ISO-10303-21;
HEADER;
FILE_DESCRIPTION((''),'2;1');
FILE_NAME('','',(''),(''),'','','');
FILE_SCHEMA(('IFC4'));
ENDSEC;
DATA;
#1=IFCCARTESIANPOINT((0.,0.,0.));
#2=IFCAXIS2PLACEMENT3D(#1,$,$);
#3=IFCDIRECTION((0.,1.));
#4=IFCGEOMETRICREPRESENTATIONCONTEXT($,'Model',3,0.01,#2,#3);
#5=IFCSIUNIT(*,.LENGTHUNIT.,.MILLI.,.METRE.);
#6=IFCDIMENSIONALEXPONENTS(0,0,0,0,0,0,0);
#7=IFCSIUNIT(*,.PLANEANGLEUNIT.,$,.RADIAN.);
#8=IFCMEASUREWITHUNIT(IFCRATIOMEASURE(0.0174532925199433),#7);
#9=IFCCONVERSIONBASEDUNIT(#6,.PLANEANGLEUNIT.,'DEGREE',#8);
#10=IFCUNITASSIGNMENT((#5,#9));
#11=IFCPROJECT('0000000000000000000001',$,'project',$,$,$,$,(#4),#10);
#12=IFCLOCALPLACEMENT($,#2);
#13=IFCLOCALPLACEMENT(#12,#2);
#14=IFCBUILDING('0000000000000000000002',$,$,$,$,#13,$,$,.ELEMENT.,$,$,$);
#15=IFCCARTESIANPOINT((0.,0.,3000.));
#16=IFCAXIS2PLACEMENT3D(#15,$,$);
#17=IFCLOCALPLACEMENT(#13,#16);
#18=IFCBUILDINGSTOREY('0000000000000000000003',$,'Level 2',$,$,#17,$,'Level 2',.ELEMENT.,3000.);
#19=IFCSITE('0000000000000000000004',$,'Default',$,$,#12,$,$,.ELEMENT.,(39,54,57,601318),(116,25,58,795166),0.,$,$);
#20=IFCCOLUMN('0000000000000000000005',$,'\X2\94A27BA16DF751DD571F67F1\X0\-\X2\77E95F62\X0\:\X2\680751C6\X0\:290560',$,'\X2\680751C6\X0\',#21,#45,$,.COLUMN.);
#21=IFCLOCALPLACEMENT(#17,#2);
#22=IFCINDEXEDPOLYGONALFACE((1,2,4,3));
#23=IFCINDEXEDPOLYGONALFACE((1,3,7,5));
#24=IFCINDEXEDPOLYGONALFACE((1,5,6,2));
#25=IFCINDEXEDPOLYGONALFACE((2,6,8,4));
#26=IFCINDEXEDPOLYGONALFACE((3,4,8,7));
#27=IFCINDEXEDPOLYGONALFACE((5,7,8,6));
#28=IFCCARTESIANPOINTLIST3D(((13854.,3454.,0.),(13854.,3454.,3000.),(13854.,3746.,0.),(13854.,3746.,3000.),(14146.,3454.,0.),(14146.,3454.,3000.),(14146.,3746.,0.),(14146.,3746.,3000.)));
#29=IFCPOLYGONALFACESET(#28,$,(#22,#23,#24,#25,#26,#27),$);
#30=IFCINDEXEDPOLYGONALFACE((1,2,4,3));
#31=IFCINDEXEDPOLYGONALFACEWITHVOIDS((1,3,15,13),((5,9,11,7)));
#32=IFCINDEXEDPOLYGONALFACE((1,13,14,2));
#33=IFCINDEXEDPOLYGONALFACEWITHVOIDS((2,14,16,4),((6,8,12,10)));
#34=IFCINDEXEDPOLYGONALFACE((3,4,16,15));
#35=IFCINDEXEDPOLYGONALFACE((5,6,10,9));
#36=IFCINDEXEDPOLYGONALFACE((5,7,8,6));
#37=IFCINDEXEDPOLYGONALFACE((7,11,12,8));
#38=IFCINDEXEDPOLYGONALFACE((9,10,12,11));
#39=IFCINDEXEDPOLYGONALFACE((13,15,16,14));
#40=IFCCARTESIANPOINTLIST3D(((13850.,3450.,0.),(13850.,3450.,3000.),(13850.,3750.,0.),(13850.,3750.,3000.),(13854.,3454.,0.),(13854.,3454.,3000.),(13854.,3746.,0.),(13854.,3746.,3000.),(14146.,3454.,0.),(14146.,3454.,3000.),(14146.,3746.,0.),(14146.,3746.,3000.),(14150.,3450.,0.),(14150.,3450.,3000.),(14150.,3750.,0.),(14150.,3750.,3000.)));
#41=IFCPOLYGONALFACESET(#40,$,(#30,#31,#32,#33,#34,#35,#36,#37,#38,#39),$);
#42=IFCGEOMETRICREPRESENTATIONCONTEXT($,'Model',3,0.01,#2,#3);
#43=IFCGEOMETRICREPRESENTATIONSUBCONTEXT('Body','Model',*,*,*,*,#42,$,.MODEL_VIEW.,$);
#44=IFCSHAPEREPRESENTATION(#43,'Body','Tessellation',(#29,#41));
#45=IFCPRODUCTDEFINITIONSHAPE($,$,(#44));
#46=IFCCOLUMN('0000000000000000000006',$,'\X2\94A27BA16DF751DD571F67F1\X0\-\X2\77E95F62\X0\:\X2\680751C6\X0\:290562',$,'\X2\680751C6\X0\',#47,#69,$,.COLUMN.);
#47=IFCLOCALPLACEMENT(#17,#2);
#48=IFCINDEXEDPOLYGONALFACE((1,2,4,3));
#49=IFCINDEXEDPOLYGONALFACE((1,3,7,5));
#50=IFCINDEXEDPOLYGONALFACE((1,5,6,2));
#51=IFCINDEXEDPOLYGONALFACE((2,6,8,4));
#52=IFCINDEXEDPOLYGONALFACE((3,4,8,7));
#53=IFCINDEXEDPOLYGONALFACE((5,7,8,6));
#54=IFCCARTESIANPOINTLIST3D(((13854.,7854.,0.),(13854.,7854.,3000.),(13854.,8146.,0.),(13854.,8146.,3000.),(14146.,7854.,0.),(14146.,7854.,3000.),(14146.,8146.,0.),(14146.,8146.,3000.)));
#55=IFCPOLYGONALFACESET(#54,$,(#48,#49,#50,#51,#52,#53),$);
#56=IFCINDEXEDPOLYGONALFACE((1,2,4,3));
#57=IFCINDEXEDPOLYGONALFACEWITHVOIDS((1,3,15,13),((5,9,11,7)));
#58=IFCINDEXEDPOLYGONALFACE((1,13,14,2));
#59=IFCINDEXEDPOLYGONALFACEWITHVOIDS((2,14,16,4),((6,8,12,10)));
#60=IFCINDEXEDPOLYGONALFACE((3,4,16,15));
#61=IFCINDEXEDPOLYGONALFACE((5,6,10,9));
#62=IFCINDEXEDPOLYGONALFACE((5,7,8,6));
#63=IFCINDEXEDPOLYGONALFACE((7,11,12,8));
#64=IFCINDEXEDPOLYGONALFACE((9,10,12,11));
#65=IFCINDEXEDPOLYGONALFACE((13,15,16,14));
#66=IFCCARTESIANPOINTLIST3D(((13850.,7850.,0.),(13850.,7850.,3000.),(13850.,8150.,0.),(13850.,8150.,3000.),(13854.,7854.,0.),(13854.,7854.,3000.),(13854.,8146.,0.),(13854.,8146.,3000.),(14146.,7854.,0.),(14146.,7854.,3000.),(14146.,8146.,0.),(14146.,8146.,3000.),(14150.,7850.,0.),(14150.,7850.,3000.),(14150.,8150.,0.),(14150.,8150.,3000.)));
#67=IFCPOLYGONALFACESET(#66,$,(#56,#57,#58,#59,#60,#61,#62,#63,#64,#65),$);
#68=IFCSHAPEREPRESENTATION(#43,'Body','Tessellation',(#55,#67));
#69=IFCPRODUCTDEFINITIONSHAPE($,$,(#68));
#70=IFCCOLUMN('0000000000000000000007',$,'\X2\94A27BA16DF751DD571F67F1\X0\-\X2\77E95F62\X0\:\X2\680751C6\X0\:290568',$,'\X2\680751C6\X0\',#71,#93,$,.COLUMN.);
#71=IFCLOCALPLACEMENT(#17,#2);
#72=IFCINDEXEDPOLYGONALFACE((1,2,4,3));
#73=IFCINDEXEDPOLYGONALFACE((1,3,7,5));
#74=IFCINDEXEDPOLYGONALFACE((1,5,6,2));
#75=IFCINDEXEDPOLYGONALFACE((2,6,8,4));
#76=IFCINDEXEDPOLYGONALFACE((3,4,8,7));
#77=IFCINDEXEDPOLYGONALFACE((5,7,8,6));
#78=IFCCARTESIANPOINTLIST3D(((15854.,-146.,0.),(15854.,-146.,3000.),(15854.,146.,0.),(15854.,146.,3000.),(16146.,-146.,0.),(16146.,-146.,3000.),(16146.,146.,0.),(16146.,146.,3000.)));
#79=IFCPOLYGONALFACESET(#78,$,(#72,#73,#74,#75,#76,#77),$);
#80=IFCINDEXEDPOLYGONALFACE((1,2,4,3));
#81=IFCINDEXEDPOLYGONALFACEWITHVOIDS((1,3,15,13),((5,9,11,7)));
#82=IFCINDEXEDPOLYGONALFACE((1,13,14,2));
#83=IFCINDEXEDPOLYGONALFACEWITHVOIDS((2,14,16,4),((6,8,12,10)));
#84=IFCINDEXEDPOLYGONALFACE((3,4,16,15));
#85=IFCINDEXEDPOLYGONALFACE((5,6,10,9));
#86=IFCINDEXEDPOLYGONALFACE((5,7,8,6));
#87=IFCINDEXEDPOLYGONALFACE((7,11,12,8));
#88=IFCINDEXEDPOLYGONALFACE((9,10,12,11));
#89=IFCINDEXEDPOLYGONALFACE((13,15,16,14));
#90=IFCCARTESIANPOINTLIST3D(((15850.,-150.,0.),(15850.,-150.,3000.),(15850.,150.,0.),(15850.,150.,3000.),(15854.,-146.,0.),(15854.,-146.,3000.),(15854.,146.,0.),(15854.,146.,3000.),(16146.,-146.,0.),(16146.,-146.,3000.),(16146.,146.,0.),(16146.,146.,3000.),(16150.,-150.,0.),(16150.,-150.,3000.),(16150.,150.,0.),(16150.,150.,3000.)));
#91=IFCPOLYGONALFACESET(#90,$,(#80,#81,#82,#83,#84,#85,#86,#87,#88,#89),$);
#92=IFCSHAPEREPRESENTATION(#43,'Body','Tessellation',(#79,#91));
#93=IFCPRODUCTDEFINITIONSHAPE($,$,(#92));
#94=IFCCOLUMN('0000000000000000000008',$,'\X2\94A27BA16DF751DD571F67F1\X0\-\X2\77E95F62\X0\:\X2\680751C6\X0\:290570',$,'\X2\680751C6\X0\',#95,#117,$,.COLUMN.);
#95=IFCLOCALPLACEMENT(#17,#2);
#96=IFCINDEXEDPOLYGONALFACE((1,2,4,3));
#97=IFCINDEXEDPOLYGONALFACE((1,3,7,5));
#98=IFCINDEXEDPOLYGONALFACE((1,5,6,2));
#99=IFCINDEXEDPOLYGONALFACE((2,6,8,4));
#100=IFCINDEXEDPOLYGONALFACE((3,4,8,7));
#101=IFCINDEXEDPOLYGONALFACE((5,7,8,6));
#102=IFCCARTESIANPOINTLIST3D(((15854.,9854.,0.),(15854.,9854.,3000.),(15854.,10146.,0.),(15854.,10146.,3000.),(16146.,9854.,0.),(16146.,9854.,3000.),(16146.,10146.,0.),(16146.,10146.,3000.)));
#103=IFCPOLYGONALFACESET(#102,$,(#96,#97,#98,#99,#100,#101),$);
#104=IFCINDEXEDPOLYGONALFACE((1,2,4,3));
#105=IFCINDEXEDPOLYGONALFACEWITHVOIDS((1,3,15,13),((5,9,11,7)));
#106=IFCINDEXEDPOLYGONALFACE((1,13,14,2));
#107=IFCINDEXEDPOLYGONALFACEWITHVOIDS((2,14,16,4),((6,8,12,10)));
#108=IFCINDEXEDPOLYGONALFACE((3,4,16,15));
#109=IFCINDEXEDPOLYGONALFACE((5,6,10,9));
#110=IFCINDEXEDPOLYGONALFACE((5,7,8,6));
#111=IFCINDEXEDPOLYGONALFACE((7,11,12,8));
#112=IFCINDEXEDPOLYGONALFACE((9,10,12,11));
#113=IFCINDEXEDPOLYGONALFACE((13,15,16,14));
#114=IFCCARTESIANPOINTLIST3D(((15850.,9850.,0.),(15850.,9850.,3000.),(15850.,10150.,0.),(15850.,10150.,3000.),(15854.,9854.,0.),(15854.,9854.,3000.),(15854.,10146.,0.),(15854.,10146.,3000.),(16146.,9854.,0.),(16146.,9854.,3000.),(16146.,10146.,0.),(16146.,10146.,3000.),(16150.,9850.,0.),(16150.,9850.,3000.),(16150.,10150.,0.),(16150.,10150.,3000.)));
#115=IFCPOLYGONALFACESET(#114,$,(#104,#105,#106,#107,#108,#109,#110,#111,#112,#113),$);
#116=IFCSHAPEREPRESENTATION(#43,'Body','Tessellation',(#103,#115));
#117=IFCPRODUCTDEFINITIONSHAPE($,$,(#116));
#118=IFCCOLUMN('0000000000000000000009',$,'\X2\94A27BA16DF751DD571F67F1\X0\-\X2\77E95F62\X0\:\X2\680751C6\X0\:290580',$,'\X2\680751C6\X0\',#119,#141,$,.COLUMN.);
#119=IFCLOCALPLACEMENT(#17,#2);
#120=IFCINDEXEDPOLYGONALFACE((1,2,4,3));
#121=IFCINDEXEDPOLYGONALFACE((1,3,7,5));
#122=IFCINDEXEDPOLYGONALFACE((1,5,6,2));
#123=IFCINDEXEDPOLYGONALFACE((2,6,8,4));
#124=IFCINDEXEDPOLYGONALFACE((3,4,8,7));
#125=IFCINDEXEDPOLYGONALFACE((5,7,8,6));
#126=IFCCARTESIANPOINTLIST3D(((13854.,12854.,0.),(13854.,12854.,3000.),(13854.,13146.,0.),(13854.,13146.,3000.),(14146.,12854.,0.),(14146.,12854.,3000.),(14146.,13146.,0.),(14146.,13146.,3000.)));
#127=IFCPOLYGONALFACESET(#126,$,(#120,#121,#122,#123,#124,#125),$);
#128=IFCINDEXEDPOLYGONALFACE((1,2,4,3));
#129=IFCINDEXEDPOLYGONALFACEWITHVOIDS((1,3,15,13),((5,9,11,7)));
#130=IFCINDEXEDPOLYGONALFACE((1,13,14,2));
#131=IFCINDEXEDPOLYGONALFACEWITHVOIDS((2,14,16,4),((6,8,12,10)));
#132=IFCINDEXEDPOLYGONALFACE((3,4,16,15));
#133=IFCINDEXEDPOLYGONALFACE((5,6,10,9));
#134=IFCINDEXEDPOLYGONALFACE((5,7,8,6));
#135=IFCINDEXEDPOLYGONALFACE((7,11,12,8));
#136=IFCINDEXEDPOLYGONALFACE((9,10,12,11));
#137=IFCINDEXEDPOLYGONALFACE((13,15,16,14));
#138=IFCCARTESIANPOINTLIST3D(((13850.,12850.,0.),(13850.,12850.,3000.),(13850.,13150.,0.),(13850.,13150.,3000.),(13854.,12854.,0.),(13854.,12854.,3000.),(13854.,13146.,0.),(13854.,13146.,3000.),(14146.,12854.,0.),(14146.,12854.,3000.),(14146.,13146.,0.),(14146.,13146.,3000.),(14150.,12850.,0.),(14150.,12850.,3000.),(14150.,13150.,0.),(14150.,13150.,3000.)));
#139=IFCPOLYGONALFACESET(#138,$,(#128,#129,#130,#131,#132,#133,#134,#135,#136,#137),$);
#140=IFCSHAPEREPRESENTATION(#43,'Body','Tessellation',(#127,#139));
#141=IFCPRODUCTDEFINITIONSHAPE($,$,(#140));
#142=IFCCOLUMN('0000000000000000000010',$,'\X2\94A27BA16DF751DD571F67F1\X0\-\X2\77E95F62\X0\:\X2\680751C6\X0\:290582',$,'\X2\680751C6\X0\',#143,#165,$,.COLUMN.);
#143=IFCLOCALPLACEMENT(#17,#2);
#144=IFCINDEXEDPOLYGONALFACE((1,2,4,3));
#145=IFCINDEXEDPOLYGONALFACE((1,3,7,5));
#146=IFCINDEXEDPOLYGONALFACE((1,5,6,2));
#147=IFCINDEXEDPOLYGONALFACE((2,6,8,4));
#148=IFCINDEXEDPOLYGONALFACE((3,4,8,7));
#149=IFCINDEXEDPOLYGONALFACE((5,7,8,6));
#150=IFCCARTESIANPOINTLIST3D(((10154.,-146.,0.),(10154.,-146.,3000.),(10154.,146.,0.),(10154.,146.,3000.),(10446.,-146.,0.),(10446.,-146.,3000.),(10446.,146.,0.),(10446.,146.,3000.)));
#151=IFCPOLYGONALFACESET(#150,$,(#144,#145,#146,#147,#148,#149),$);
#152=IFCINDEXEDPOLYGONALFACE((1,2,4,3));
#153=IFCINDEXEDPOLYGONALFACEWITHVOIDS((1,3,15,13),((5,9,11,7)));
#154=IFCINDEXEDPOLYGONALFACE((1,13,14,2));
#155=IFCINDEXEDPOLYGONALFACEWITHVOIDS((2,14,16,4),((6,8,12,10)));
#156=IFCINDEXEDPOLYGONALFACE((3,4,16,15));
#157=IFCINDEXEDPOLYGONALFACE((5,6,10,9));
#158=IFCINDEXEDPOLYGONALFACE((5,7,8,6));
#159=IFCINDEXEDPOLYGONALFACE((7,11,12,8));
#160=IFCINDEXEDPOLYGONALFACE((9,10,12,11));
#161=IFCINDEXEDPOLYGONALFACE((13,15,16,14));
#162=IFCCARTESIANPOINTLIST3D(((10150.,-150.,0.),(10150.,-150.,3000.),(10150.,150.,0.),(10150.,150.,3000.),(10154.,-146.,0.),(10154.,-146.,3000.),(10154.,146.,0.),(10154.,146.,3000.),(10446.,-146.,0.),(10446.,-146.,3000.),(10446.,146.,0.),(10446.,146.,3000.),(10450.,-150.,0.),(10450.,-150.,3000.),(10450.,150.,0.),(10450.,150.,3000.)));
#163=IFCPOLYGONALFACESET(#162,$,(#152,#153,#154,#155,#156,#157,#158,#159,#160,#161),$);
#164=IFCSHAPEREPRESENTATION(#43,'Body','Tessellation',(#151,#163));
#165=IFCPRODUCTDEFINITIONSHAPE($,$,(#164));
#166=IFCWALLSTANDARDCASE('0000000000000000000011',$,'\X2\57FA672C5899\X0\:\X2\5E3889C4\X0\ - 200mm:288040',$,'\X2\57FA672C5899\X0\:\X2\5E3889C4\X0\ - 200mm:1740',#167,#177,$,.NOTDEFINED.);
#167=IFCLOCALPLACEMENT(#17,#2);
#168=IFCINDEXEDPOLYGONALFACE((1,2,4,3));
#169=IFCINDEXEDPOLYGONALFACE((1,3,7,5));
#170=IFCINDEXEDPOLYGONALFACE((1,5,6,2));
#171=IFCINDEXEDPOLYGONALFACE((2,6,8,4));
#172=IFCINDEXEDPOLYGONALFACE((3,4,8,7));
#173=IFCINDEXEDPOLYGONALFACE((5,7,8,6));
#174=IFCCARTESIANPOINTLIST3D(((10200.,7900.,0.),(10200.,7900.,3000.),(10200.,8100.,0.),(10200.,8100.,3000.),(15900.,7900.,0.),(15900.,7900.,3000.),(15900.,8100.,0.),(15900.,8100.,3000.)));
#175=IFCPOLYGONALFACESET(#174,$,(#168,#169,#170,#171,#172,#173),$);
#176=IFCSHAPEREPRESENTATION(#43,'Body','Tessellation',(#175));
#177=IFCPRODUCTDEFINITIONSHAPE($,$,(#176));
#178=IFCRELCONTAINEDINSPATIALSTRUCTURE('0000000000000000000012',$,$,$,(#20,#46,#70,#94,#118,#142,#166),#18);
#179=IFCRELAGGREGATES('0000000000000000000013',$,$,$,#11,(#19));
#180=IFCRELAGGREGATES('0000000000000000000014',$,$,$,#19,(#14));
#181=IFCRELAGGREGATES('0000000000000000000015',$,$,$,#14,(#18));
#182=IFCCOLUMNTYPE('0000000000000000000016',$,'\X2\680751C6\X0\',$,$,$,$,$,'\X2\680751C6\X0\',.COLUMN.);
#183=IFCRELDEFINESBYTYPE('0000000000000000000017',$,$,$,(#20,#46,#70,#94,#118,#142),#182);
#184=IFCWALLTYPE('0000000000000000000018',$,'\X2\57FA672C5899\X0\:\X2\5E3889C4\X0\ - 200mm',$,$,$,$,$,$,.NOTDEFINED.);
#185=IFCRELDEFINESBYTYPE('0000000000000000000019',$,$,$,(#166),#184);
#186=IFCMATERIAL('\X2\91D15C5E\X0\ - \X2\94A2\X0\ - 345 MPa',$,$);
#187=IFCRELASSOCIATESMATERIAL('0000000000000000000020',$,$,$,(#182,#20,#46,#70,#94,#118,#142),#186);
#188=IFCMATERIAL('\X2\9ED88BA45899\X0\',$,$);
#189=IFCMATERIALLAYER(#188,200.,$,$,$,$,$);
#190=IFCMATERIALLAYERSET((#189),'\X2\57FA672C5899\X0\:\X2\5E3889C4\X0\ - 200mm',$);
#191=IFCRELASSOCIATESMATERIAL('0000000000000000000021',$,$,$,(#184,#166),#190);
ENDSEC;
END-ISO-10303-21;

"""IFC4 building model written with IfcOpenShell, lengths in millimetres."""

from ifc_helpers import new_model, entity, si_unit, converted_unit, direction, frame, frame_2d, origin, origin_2d_with_axis, place, context, subcontext, project, spatial, polyline, rectangle, outline, extrude, source, transform, mapped, material, layer, layer_set, layer_usage, type_object, type_shapes, element, save


model = new_model("IFC4")

# Units and contexts
model_context_1 = context("Model", 3, precision=0.01, world=origin(), true_north=direction((0.0, 1.0)))
model_context_2 = context("Model", 3, precision=0.01, world=origin(), true_north=direction((0.0, 1.0)))
body_context = subcontext(model_context_2, "Body", "Model", "MODEL_VIEW")
ifc_project = project(units=[si_unit("LENGTHUNIT", "METRE", prefix="MILLI"), converted_unit("PLANEANGLEUNIT", "DEGREE", entity("IfcRatioMeasure", 0.0174532925199433), si_unit("PLANEANGLEUNIT", "RADIAN"), dimensions=[0, 0, 0, 0, 0, 0, 0])], contexts=[model_context_1])

# Site, building, storey
site_placement = place(None, origin())
site = spatial("IfcSite", under=ifc_project, at=site_placement, Name="Default", CompositionType="ELEMENT", RefLatitude=(39, 54, 57, 601318), RefLongitude=(116, 25, 58, 795166), RefElevation=0.0)
building_placement = place(site_placement, origin())
building = spatial("IfcBuilding", under=site, at=building_placement, CompositionType="ELEMENT")
storey_placement = place(building_placement, frame((0.0, 0.0, 3000.0)))
storey = spatial("IfcBuildingStorey", under=building, at=storey_placement, Name="Level 2", LongName="Level 2", CompositionType="ELEMENT", Elevation=3000.0)

# Columns
ifc_material_1 = material(Name="金属 - 钢 - 345 MPa")
column_type = type_object("IfcColumnType", Name="标准", ElementType="标准", PredefinedType="COLUMN", material=ifc_material_1)
shared_shape_1 = source(origin(), body_context, "Body", "SweptSolid", [
    extrude(rectangle(XDim=292.0, YDim=292.0, at=origin_2d_with_axis()), frame((150.0, 150.0, 0.0), z_axis=(0.0, 0.0, 1.0), x_axis=(-1.0, 0.0, 0.0)), (0.0, 0.0, 1.0), 3000.0),
    extrude(outline(polyline([(-150.0, -150.0), (150.0, -150.0), (150.0, 150.0), (-150.0, 150.0), (-150.0, -150.0)]), holes=[polyline([(-146.0, -146.0), (-146.0, 146.0), (146.0, 146.0), (146.0, -146.0), (-146.0, -146.0)])]), frame((150.0, 150.0, 0.0), z_axis=(0.0, 0.0, 1.0), x_axis=(-1.0, 0.0, 0.0)), (0.0, 0.0, 1.0), 3000.0),
])
type_shapes(column_type, [shared_shape_1])
for number, where, name in (
    (1, (13850.0, 3450.0, 0.0), "钢管混凝土柱-矩形:标准:290560"),
    (2, (13850.0, 7850.0, 0.0), "钢管混凝土柱-矩形:标准:290562"),
    (3, (15850.0, -150.0, 0.0), "钢管混凝土柱-矩形:标准:290568"),
    (4, (15850.0, 9850.0, 0.0), "钢管混凝土柱-矩形:标准:290570"),
    (5, (13850.0, 12850.0, 0.0), "钢管混凝土柱-矩形:标准:290580"),
    (6, (10150.0, -150.0, 0.0), "钢管混凝土柱-矩形:标准:290582"),
):
    element("IfcColumn", number, at=place(storey_placement, frame(where)), inside=storey, type_object=column_type, material=ifc_material_1, Name=name, ObjectType="标准", PredefinedType="COLUMN", context=body_context, shape_type="MappedRepresentation", body=[
        mapped(shared_shape_1, transform((0.0, 0.0, 0.0), scale=1.0)),
    ])

# Wall
ifc_material_2 = material(Name="默认墙")
ifc_layer = layer(ifc_material_2, 200.0)
ifc_layer_set = layer_set([ifc_layer], Name="基本墙:常规 - 200mm")
ifc_layer_usage_1 = layer_usage(ifc_layer_set, "AXIS2", "NEGATIVE", 100.0)
wall_type = type_object("IfcWallType", Name="基本墙:常规 - 200mm", PredefinedType="NOTDEFINED", material=ifc_layer_set)
wall_1_placement = place(storey_placement, frame((10200.0, 8000.0, 0.0)))
element("IfcWallStandardCase", 7, at=wall_1_placement, inside=storey, type_object=wall_type, material=ifc_layer_usage_1, Name="基本墙:常规 - 200mm:288040", ObjectType="基本墙:常规 - 200mm:1740", PredefinedType="NOTDEFINED", context=body_context, shape_type="SweptSolid", body=[
    extrude(rectangle(XDim=5700.0, YDim=200.0, at=frame_2d((2850.0, 0.0), x_axis=(-1.0, 0.0))), origin(), (0.0, 0.0, 1.0), 3000.0),
])

save(model, "model.ifc")
